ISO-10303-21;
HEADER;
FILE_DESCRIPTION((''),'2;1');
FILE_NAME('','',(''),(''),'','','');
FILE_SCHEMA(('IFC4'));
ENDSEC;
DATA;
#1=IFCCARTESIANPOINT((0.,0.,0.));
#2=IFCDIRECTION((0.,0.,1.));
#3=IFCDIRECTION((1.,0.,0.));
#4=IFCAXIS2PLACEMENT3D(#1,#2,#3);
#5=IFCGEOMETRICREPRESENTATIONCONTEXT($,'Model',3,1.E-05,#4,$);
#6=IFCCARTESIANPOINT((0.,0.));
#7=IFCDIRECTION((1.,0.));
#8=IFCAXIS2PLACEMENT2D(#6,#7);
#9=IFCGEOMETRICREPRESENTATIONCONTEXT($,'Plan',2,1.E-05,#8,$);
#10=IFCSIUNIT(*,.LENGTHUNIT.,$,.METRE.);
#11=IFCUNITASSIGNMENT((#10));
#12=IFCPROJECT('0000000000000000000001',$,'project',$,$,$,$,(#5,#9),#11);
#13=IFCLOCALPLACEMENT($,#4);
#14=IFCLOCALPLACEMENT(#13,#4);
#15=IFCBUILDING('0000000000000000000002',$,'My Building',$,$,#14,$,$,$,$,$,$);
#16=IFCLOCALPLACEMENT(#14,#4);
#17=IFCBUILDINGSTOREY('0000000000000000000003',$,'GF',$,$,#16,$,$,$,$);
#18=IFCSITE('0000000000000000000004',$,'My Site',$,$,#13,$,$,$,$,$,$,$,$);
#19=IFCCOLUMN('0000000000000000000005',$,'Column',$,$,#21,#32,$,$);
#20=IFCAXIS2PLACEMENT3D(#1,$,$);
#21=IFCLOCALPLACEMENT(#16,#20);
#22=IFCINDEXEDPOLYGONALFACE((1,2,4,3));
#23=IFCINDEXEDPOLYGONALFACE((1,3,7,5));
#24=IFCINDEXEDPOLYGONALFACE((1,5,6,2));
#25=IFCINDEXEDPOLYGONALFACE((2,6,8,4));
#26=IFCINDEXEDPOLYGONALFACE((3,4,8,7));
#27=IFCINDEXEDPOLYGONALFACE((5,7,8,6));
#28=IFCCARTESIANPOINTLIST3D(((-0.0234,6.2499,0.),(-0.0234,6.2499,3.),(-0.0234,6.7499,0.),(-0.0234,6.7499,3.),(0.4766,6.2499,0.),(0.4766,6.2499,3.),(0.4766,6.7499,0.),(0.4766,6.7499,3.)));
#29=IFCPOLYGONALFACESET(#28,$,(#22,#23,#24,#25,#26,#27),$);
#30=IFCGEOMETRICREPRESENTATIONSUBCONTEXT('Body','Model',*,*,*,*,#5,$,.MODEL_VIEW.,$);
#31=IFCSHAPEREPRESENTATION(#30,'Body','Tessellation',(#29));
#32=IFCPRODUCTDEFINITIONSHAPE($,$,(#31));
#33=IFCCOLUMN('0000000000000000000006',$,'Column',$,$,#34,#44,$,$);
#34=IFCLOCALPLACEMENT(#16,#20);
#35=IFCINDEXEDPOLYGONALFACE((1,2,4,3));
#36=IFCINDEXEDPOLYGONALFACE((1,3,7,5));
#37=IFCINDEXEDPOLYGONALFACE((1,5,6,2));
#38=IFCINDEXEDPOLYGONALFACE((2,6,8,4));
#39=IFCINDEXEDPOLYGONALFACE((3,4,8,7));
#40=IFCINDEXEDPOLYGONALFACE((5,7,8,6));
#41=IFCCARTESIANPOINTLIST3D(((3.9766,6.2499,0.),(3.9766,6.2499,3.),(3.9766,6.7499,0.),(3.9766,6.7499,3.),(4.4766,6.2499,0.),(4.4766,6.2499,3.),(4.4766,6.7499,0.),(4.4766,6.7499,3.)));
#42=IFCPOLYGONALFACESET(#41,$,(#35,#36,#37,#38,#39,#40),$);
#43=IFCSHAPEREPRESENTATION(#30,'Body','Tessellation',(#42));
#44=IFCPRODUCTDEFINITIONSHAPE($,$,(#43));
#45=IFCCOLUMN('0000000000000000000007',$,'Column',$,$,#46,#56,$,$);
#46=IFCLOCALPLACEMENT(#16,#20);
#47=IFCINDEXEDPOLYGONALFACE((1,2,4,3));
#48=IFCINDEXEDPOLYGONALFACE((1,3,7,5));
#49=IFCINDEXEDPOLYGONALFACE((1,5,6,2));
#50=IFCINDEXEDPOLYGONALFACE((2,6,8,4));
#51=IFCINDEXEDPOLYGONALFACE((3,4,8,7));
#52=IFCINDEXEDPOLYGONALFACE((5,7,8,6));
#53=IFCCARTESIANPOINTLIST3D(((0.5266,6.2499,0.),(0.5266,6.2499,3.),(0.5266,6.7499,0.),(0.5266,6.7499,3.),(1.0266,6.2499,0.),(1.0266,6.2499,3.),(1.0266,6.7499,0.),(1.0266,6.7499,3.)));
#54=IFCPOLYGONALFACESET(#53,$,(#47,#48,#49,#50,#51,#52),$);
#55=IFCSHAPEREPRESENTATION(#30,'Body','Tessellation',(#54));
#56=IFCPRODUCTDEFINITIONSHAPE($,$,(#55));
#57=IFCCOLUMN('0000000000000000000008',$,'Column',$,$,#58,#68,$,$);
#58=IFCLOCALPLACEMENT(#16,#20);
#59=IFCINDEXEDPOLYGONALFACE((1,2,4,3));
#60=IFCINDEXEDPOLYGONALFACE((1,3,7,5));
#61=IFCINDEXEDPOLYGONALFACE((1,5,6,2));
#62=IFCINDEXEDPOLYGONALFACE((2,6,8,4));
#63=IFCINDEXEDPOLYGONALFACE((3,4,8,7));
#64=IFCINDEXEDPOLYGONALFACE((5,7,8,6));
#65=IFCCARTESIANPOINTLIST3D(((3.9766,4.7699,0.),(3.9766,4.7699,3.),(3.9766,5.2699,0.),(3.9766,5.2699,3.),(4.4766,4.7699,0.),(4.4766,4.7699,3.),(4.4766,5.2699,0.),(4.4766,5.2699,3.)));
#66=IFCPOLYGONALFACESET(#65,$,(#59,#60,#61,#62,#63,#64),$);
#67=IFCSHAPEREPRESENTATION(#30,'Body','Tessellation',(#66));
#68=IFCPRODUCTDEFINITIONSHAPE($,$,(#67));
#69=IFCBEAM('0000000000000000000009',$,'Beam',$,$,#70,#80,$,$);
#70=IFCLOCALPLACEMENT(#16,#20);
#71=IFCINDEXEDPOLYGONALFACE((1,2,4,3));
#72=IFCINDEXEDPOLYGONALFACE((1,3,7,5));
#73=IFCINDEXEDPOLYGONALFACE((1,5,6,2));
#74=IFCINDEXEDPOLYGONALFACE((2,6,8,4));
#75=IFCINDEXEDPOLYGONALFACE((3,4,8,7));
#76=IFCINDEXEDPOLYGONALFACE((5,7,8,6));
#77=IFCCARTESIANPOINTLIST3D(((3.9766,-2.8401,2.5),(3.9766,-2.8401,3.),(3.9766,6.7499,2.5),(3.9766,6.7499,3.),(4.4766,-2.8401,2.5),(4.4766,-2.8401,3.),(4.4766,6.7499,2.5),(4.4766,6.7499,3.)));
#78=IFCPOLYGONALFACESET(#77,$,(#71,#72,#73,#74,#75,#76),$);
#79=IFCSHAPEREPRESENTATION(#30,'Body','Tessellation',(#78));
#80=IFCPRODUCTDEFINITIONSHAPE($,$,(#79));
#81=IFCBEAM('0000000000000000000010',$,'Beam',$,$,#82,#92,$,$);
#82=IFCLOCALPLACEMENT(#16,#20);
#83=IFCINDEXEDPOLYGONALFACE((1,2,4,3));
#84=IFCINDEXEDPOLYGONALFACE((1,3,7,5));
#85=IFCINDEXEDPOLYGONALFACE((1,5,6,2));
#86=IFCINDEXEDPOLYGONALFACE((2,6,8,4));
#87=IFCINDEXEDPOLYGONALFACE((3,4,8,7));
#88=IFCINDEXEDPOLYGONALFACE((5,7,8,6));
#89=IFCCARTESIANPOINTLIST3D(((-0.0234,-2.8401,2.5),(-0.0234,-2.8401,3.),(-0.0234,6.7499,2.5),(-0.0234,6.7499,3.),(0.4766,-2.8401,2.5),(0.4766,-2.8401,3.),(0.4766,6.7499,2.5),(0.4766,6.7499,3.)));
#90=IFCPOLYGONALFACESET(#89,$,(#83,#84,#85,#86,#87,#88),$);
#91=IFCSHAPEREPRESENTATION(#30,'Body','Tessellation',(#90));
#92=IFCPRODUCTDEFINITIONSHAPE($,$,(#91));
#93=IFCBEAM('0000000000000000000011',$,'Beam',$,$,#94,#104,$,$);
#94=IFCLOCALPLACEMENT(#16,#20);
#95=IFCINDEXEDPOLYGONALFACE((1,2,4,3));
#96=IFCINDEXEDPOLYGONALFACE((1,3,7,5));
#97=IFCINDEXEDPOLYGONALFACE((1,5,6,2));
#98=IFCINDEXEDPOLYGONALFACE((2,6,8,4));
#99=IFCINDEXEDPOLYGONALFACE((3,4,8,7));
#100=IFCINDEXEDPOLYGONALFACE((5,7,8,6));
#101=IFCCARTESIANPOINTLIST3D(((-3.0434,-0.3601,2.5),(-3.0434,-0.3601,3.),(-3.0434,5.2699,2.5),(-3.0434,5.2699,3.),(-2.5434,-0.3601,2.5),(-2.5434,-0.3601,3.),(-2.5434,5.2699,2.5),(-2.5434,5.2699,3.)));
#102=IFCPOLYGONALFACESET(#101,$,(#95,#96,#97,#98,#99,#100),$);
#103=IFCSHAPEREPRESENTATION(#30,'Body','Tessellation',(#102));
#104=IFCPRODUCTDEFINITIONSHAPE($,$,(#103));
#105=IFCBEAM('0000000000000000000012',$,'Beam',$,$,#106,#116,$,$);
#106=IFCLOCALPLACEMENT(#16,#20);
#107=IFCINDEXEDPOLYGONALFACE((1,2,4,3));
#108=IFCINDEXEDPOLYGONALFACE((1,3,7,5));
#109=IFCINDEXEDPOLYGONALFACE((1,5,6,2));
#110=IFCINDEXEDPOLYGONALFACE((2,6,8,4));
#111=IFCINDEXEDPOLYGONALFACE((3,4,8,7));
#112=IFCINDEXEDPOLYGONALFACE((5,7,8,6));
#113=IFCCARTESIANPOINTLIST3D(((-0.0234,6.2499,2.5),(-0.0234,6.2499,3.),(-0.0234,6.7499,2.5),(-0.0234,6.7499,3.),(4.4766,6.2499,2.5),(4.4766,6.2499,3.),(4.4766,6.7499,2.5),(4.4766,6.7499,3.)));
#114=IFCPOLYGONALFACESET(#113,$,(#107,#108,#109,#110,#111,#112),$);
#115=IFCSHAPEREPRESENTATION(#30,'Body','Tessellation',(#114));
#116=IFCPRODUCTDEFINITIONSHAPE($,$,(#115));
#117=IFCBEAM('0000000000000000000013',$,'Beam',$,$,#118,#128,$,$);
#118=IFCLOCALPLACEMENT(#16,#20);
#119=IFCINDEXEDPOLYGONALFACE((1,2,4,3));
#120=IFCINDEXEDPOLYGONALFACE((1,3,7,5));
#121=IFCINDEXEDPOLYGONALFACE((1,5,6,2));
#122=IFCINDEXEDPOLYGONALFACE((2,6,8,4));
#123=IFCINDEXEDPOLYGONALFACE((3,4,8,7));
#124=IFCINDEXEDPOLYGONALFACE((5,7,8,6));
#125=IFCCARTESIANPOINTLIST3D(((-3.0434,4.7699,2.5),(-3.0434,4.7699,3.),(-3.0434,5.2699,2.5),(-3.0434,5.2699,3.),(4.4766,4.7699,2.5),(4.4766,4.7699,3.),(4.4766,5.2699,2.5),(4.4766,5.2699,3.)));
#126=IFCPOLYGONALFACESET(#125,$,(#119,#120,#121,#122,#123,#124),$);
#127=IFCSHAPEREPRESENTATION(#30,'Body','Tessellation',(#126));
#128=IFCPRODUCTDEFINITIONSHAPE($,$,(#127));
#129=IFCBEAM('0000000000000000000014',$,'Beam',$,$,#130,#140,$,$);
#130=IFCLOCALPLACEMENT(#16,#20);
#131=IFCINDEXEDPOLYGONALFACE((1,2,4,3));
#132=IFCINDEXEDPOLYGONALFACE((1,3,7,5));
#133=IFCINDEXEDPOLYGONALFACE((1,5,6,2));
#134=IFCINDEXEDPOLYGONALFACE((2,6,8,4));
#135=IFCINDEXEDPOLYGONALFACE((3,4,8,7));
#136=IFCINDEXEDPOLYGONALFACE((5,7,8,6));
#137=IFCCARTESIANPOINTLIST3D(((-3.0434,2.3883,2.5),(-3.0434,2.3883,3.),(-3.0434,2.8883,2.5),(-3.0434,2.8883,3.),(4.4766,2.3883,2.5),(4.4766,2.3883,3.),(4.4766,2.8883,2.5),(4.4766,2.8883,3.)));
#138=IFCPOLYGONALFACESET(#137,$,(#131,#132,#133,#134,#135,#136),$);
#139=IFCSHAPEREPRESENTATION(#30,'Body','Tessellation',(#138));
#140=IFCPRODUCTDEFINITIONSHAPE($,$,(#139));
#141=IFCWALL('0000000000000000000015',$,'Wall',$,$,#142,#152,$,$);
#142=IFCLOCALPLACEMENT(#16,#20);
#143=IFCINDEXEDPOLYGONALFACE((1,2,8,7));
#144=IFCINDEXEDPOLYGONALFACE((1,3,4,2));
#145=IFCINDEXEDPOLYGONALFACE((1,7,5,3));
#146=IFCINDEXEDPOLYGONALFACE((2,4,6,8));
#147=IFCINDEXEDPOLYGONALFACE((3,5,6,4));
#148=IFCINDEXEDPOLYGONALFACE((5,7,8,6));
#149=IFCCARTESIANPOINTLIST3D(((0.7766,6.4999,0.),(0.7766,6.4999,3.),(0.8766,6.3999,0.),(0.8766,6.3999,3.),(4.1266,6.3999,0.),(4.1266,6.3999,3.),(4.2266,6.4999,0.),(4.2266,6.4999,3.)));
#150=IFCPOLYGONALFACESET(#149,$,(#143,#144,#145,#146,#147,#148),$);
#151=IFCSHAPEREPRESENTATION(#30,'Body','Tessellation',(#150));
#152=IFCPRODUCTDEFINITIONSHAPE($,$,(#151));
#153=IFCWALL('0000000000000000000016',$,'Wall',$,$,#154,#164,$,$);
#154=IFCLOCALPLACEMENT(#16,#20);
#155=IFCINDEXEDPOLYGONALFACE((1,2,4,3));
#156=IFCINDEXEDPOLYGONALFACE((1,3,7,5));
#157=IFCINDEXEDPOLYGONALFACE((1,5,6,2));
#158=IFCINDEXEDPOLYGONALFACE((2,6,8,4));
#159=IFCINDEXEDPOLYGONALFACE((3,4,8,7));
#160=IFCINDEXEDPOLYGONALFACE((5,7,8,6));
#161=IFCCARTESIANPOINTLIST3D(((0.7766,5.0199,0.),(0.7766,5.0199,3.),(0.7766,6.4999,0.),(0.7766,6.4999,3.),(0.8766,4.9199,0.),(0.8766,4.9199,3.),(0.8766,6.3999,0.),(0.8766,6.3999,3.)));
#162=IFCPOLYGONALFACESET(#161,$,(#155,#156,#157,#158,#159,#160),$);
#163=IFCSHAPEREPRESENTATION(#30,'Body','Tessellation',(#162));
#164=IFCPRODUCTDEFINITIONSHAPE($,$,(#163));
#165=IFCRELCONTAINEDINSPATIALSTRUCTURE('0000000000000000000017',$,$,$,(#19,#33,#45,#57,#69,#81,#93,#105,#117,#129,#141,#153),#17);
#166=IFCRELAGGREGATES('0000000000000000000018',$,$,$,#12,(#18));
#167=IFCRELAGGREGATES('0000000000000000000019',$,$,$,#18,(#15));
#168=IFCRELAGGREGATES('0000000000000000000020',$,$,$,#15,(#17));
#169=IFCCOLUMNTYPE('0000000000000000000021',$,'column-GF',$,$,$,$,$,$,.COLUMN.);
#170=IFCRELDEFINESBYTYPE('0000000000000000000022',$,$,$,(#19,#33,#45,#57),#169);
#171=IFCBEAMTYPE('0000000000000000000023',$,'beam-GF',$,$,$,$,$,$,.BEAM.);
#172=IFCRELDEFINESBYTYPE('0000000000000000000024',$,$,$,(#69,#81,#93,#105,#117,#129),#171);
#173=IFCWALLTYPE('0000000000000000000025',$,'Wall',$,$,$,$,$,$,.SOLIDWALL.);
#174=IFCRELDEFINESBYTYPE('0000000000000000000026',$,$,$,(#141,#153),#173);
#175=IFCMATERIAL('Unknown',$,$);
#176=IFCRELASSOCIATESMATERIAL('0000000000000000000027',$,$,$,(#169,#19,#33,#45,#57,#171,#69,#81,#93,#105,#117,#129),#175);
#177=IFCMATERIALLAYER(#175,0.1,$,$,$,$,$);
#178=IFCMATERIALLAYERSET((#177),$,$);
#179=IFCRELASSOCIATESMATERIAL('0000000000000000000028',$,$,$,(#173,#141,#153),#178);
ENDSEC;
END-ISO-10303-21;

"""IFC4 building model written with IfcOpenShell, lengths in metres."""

from ifc_helpers import new_model, si_unit, frame, origin_with_axes, origin_2d_with_axis, place, context, subcontext, project, spatial, line, indexed_curve, rectangle, outline, extrude, material, layer, layer_set, layer_usage, material_profile, profile_set, profile_usage, type_object, element, save


model = new_model("IFC4")

# Units and contexts
model_context = context("Model", 3, precision=1e-05, world=origin_with_axes())
plan_context = context("Plan", 2, precision=1e-05, world=origin_2d_with_axis())
body_context_1 = subcontext(model_context, "Body", "Model", "MODEL_VIEW")
ifc_project = project(units=[si_unit("LENGTHUNIT", "METRE")], contexts=[model_context, plan_context])

# Site, building, storey
site_placement = place(None, origin_with_axes())
site = spatial("IfcSite", under=ifc_project, at=site_placement, Name="My Site")
building_placement = place(site_placement, origin_with_axes())
building = spatial("IfcBuilding", under=site, at=building_placement, Name="My Building")
storey_placement = place(building_placement, origin_with_axes())
storey = spatial("IfcBuildingStorey", under=building, at=storey_placement, Name="GF")

# Columns
ifc_material_1 = material(Name="Unknown")
ifc_material_profile_1 = material_profile(ifc_material_1, rectangle(XDim=0.5, YDim=0.5))
ifc_profile_set_1 = profile_set([ifc_material_profile_1])
ifc_profile_usage_1 = profile_usage(ifc_profile_set_1, cardinal=5)
column_type = type_object("IfcColumnType", Name="column-GF", PredefinedType="COLUMN", material=ifc_profile_set_1)
column_1_placement = place(storey_placement, frame((0.2266, 6.4999, 0.0), z_axis=(0.0, 0.0, 1.0), x_axis=(1.0, 0.0, 0.0)))
element("IfcColumn", 1, at=column_1_placement, inside=storey, type_object=column_type, material=ifc_profile_usage_1, Name="Column", context=body_context_1, shape_type="SweptSolid", body=[
    extrude(rectangle(XDim=0.5, YDim=0.5), origin_with_axes(), (0.0, 0.0, 1.0), 3.0),
])
ifc_profile_usage_2 = profile_usage(ifc_profile_set_1, cardinal=5)
column_2_placement = place(storey_placement, frame((4.2266, 6.4999, 0.0), z_axis=(0.0, 0.0, 1.0), x_axis=(1.0, 0.0, 0.0)))
element("IfcColumn", 2, at=column_2_placement, inside=storey, type_object=column_type, material=ifc_profile_usage_2, Name="Column", context=body_context_1, shape_type="SweptSolid", body=[
    extrude(rectangle(XDim=0.5, YDim=0.5), origin_with_axes(), (0.0, 0.0, 1.0), 3.0),
])
ifc_profile_usage_3 = profile_usage(ifc_profile_set_1, cardinal=5)
column_3_placement = place(storey_placement, frame((0.7766, 6.4999, 0.0), z_axis=(0.0, 0.0, 1.0), x_axis=(1.0, 0.0, 0.0)))
element("IfcColumn", 3, at=column_3_placement, inside=storey, type_object=column_type, material=ifc_profile_usage_3, Name="Column", context=body_context_1, shape_type="SweptSolid", body=[
    extrude(rectangle(XDim=0.5, YDim=0.5), origin_with_axes(), (0.0, 0.0, 1.0), 3.0),
])
ifc_profile_usage_4 = profile_usage(ifc_profile_set_1, cardinal=5)
column_4_placement = place(storey_placement, frame((4.2266, 5.0199, 0.0), z_axis=(0.0, 0.0, 1.0), x_axis=(1.0, 0.0, 0.0)))
element("IfcColumn", 4, at=column_4_placement, inside=storey, type_object=column_type, material=ifc_profile_usage_4, Name="Column", context=body_context_1, shape_type="SweptSolid", body=[
    extrude(rectangle(XDim=0.5, YDim=0.5), origin_with_axes(), (0.0, 0.0, 1.0), 3.0),
])

# Beams
ifc_material_profile_2 = material_profile(ifc_material_1, rectangle(XDim=0.5, YDim=0.5))
ifc_profile_set_2 = profile_set([ifc_material_profile_2])
ifc_profile_usage_5 = profile_usage(ifc_profile_set_2, cardinal=7)
beam_type = type_object("IfcBeamType", Name="beam-GF", PredefinedType="BEAM", material=ifc_profile_set_2)
beam_1_placement = place(storey_placement, frame((4.4766, 6.7499, 3.0), z_axis=(0.0, -1.0, 0.0), x_axis=(1.0, 0.0, 0.0)))
element("IfcBeam", 5, at=beam_1_placement, inside=storey, type_object=beam_type, material=ifc_profile_usage_5, Name="Beam", context=body_context_1, shape_type="SweptSolid", body=[
    extrude(rectangle(XDim=0.5, YDim=0.5), frame((-0.25, -0.25, 0.0), z_axis=(0.0, 0.0, 1.0), x_axis=(1.0, 0.0, 0.0)), (0.0, 0.0, 1.0), 9.59),
])
ifc_profile_usage_6 = profile_usage(ifc_profile_set_2, cardinal=7)
beam_2_placement = place(storey_placement, frame((0.4766, 6.7499, 3.0), z_axis=(0.0, -1.0, 0.0), x_axis=(1.0, 0.0, 0.0)))
element("IfcBeam", 6, at=beam_2_placement, inside=storey, type_object=beam_type, material=ifc_profile_usage_6, Name="Beam", context=body_context_1, shape_type="SweptSolid", body=[
    extrude(rectangle(XDim=0.5, YDim=0.5), frame((-0.25, -0.25, 0.0), z_axis=(0.0, 0.0, 1.0), x_axis=(1.0, 0.0, 0.0)), (0.0, 0.0, 1.0), 9.59),
])
ifc_profile_usage_7 = profile_usage(ifc_profile_set_2, cardinal=7)
beam_3_placement = place(storey_placement, frame((-2.5434, 5.2699, 3.0), z_axis=(0.0, -1.0, 0.0), x_axis=(1.0, 0.0, 0.0)))
element("IfcBeam", 7, at=beam_3_placement, inside=storey, type_object=beam_type, material=ifc_profile_usage_7, Name="Beam", context=body_context_1, shape_type="SweptSolid", body=[
    extrude(rectangle(XDim=0.5, YDim=0.5), frame((-0.25, -0.25, 0.0), z_axis=(0.0, 0.0, 1.0), x_axis=(1.0, 0.0, 0.0)), (0.0, 0.0, 1.0), 5.63),
])
ifc_profile_usage_8 = profile_usage(ifc_profile_set_2, cardinal=7)
beam_4_placement = place(storey_placement, frame((-0.0234, 6.7499, 3.0), z_axis=(1.0, -0.000001, 0.000001), x_axis=(0.000001, 1.0, 0.0)))
element("IfcBeam", 8, at=beam_4_placement, inside=storey, type_object=beam_type, material=ifc_profile_usage_8, Name="Beam", context=body_context_1, shape_type="SweptSolid", body=[
    extrude(rectangle(XDim=0.5, YDim=0.5), frame((-0.25, -0.25, 0.0), z_axis=(0.0, 0.0, 1.0), x_axis=(1.0, 0.0, 0.0)), (0.0, 0.0, 1.0), 4.5),
])
ifc_profile_usage_9 = profile_usage(ifc_profile_set_2, cardinal=7)
beam_5_placement = place(storey_placement, frame((-3.0434, 5.2699, 3.0), z_axis=(1.0, -0.000001, 0.000001), x_axis=(0.000001, 1.0, 0.0)))
element("IfcBeam", 9, at=beam_5_placement, inside=storey, type_object=beam_type, material=ifc_profile_usage_9, Name="Beam", context=body_context_1, shape_type="SweptSolid", body=[
    extrude(rectangle(XDim=0.5, YDim=0.5), frame((-0.25, -0.25, 0.0), z_axis=(0.0, 0.0, 1.0), x_axis=(1.0, 0.0, 0.0)), (0.0, 0.0, 1.0), 7.52),
])
ifc_profile_usage_10 = profile_usage(ifc_profile_set_2, cardinal=7)
beam_6_placement = place(storey_placement, frame((-3.0434, 2.8883, 3.0), z_axis=(1.0, -0.000001, 0.000001), x_axis=(0.000001, 1.0, 0.0)))
element("IfcBeam", 10, at=beam_6_placement, inside=storey, type_object=beam_type, material=ifc_profile_usage_10, Name="Beam", context=body_context_1, shape_type="SweptSolid", body=[
    extrude(rectangle(XDim=0.5, YDim=0.5), frame((-0.25, -0.25, 0.0), z_axis=(0.0, 0.0, 1.0), x_axis=(1.0, 0.0, 0.0)), (0.0, 0.0, 1.0), 7.52),
])

# Walls
ifc_layer_1 = layer(ifc_material_1, 0.1)
ifc_layer_set_1 = layer_set([ifc_layer_1])
ifc_layer_usage_1 = layer_usage(ifc_layer_set_1, "AXIS2", "POSITIVE", 0.0)
wall_type = type_object("IfcWallType", Name="Wall", PredefinedType="SOLIDWALL", material=ifc_layer_set_1)
wall_1_placement = place(storey_placement, frame((4.2266, 6.4999, 0.0), z_axis=(0.0, 0.0, 1.0), x_axis=(-1.0, 0.0, 0.0)))
element("IfcWall", 11, at=wall_1_placement, inside=storey, type_object=wall_type, material=ifc_layer_usage_1, Name="Wall", context=body_context_1, shape_type="SweptSolid", body=[
    extrude(outline(indexed_curve([(0.0, 0.0), (0.1, 0.1), (3.35, 0.1), (3.45, 0.0)], segments=[line(1, 2, 3, 4, 1)])), origin_with_axes(), (0.0, 0.0, 1.0), 3.0),
])
ifc_layer_usage_2 = layer_usage(ifc_layer_set_1, "AXIS2", "POSITIVE", 0.0)
wall_2_placement = place(storey_placement, frame((0.7766, 6.4999, 0.0), z_axis=(0.0, 0.0, 1.0), x_axis=(0.0, -1.0, 0.0)))
element("IfcWall", 12, at=wall_2_placement, inside=storey, type_object=wall_type, material=ifc_layer_usage_2, Name="Wall", context=body_context_1, shape_type="SweptSolid", body=[
    extrude(outline(indexed_curve([(0.0, 0.0), (0.1, 0.1), (1.58, 0.1), (1.48, 0.0)], segments=[line(1, 2, 3, 4, 1)])), origin_with_axes(), (0.0, 0.0, 1.0), 3.0),
])

save(model, "model.ifc")
